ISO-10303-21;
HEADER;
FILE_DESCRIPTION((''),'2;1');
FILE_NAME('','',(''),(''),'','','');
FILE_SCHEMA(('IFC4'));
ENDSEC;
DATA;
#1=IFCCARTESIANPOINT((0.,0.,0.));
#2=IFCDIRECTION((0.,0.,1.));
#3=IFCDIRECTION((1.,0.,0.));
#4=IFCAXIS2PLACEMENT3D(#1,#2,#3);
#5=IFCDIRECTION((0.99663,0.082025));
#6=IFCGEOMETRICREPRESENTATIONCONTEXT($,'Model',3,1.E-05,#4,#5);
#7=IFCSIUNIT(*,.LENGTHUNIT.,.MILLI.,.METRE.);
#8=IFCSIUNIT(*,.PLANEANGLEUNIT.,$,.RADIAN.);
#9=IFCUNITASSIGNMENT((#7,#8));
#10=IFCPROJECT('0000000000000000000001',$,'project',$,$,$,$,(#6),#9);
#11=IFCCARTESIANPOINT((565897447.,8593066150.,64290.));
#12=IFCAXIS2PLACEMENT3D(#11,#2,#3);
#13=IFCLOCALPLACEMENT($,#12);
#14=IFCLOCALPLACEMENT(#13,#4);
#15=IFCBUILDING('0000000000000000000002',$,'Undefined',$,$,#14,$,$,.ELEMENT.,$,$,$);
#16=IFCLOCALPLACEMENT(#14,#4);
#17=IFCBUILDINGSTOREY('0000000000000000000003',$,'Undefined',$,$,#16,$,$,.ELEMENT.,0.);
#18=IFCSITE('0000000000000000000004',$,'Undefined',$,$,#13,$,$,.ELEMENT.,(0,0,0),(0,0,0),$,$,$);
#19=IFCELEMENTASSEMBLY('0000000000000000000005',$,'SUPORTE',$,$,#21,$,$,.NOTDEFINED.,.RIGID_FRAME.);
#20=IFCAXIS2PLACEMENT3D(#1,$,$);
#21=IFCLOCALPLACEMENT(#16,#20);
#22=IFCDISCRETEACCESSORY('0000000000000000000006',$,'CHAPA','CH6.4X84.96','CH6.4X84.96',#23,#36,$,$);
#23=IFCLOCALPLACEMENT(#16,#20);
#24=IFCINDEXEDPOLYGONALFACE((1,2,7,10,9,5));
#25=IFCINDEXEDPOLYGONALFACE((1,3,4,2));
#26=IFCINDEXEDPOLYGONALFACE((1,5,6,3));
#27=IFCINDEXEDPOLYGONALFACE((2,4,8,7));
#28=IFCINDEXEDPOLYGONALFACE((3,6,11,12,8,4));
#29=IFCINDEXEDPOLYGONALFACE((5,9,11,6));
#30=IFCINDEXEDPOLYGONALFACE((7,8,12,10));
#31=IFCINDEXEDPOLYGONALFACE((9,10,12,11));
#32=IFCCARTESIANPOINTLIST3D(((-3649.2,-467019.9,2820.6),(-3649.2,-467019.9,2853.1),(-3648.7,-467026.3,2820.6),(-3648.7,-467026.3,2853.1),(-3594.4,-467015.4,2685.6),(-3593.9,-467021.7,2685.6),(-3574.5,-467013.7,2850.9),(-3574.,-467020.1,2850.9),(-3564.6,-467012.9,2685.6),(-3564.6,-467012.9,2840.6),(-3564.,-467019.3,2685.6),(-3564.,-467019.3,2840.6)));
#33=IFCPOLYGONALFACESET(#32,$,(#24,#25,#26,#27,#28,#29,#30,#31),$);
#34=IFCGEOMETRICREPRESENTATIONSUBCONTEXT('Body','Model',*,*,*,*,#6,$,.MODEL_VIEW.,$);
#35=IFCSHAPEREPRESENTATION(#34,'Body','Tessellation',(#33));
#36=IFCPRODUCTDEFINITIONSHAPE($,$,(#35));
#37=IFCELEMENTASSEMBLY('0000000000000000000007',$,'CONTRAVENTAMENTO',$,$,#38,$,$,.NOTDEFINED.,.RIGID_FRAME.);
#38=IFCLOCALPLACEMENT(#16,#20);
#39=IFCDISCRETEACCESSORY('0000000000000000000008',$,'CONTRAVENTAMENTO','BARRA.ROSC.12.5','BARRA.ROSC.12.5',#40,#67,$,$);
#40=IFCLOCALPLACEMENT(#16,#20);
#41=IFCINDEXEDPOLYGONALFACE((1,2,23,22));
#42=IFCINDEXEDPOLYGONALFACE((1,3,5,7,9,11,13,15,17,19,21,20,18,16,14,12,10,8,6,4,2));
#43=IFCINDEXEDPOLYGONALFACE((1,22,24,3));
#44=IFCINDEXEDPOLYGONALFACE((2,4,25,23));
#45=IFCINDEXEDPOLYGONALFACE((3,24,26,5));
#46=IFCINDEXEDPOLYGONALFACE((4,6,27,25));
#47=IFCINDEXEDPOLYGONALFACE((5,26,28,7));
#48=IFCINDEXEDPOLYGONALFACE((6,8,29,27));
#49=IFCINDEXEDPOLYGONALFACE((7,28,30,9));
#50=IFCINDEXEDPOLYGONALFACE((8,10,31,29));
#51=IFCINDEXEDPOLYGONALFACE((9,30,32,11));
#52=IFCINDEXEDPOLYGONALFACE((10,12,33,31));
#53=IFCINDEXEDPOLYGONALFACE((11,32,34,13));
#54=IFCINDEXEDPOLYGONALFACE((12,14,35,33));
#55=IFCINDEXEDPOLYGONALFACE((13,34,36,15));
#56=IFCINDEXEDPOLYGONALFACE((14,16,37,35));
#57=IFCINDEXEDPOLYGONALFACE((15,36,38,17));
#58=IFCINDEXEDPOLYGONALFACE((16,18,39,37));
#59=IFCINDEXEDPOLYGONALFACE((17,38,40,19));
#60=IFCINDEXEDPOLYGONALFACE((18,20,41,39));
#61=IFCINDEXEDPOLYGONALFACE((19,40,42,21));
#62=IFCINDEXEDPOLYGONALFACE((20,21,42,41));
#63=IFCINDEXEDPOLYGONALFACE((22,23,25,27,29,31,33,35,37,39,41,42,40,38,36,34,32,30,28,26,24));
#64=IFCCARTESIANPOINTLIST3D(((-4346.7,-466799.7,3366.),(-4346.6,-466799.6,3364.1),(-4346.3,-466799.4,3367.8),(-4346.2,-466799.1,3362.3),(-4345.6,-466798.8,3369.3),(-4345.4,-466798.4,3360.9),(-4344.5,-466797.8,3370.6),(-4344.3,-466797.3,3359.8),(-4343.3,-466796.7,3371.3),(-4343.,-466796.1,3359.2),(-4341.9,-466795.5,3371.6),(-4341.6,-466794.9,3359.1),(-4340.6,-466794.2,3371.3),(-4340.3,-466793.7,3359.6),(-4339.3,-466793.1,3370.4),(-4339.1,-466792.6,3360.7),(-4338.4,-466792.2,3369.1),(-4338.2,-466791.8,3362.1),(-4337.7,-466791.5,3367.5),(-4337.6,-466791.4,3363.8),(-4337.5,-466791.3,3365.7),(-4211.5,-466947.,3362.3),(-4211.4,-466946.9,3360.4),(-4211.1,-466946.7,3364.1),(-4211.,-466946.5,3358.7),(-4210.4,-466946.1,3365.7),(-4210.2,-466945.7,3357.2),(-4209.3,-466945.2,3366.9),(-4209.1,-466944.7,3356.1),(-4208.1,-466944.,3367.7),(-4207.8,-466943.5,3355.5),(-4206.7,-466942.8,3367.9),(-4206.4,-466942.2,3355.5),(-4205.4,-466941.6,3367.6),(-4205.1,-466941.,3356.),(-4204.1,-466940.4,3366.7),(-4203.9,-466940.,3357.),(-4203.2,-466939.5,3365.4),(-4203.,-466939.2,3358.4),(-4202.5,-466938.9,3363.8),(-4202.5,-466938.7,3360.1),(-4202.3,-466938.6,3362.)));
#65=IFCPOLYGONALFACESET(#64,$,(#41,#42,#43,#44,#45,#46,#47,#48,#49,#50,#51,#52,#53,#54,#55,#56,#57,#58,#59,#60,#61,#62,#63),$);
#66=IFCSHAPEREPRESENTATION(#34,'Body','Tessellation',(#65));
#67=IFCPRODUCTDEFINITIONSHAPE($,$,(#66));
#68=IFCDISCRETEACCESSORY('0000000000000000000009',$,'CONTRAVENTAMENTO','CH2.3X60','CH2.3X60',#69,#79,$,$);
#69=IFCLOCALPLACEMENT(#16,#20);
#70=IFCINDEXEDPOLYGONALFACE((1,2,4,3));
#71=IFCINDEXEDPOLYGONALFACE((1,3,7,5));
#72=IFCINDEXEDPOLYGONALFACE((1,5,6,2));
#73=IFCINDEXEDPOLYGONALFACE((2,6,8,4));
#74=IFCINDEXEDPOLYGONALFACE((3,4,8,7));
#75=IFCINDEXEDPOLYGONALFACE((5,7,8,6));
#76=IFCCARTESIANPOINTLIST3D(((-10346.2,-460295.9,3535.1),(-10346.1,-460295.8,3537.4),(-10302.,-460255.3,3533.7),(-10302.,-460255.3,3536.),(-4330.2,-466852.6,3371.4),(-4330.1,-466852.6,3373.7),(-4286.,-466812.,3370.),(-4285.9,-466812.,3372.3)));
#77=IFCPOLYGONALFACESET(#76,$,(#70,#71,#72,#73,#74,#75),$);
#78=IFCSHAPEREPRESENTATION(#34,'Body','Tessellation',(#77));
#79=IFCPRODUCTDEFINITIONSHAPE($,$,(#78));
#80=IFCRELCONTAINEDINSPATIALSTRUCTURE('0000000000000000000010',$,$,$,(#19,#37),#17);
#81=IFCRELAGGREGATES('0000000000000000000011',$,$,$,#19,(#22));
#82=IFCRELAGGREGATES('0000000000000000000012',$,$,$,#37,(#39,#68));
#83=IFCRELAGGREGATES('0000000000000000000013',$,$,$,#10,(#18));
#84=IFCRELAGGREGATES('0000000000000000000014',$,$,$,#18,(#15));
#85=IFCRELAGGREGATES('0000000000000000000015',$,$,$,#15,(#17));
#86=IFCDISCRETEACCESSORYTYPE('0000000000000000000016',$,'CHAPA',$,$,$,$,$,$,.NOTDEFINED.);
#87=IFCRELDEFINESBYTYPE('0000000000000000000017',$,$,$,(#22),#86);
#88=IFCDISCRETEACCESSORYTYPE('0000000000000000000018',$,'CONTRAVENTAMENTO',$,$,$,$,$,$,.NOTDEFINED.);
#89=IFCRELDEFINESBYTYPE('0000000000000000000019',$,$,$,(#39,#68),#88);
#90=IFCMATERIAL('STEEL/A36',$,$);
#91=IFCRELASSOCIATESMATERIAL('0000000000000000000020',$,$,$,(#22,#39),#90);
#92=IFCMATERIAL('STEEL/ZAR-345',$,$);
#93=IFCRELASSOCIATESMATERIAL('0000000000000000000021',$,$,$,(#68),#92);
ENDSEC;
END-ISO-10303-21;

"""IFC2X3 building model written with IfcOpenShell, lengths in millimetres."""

from ifc_helpers import new_model, si_unit, direction, frame, origin_with_axes, origin_2d_with_axis, place, context, subcontext, project, spatial, polyline, circle, outline, extrude, material, type_object, element, aggregate, save


model = new_model("IFC2X3")

# Units and contexts
model_context = context("Model", 3, precision=1e-05, world=origin_with_axes(), true_north=direction((0.99663, 0.082025)))
body_context = subcontext(model_context, "Body", "Model", "MODEL_VIEW")
ifc_project = project(units=[si_unit("LENGTHUNIT", "METRE", prefix="MILLI"), si_unit("PLANEANGLEUNIT", "RADIAN")], contexts=[model_context])

# Site, building, storey
site_placement = place(None, frame((565897447.0, 8593066150.0, 64290.0), z_axis=(0.0, 0.0, 1.0), x_axis=(1.0, 0.0, 0.0)))
site = spatial("IfcSite", under=ifc_project, at=site_placement, Name="Undefined", CompositionType="ELEMENT", RefLatitude=(0, 0, 0), RefLongitude=(0, 0, 0))
building_placement = place(site_placement, origin_with_axes())
building = spatial("IfcBuilding", under=site, at=building_placement, Name="Undefined", CompositionType="ELEMENT")
storey_placement = place(building_placement, origin_with_axes())
storey = spatial("IfcBuildingStorey", under=building, at=storey_placement, Name="Undefined", CompositionType="ELEMENT", Elevation=0.0)

# Shared definitions
ifc_material_1 = material(Name="STEEL/A36")

# Shared definitions
discrete_accessory_type_1 = type_object("IfcDiscreteAccessoryType", Name="CHAPA")

# Element assembly, discrete accessory
assembly_1_placement = place(storey_placement, origin_with_axes())
assembly_1 = element("IfcElementAssembly", 1, at=assembly_1_placement, inside=storey, Name="SUPORTE", AssemblyPlace="NOTDEFINED", PredefinedType="RIGID_FRAME")
discrete_accessory_1_placement = place(assembly_1_placement, frame((-3564.3, -467016.1, 2850.6), z_axis=(-0.082025, 0.99663, 0.0), x_axis=(0.0, 0.0, -1.0)))
discrete_accessory_1 = element("IfcDiscreteAccessory", 2, at=discrete_accessory_1_placement, type_object=discrete_accessory_type_1, material=ifc_material_1, Name="CHAPA", Description="CH6.4X84.96", ObjectType="CH6.4X84.96", context=body_context, shape_type="SweptSolid", body=[
    extrude(outline(polyline([(-0.3, 10.0), (10.0, 0.0), (165.0, 0.0), (165.0, 30.0), (30.0, 85.0), (-2.5, 85.0), (-0.3, 10.0)])), frame((0.0, 0.0, -3.2), z_axis=(0.0, 0.0, 1.0), x_axis=(1.0, 0.0, 0.0)), (0.0, 0.0, 1.0), 6.4),
])
aggregate(assembly_1, [discrete_accessory_1])

# Element assembly, discrete accessories
assembly_2_placement = place(storey_placement, origin_with_axes())
assembly_2 = element("IfcElementAssembly", 3, at=assembly_2_placement, inside=storey, Name="CONTRAVENTAMENTO", AssemblyPlace="NOTDEFINED", PredefinedType="RIGID_FRAME")
discrete_accessory_type_2 = type_object("IfcDiscreteAccessoryType", Name="CONTRAVENTAMENTO")
discrete_accessory_2_placement = place(assembly_2_placement, frame((-4206.9, -466942.8, 3361.7), z_axis=(-0.736334, -0.676203, 0.02368), x_axis=(-0.675958, 0.736711, 0.018398)))
discrete_accessory_2 = element("IfcDiscreteAccessory", 4, at=discrete_accessory_2_placement, type_object=discrete_accessory_type_2, material=ifc_material_1, Name="CONTRAVENTAMENTO", Description="BARRA.ROSC.12.5", ObjectType="BARRA.ROSC.12.5", context=body_context, shape_type="SweptSolid", body=[
    extrude(circle(Radius=6.2, at=origin_2d_with_axis()), frame((200.0, 0.0, 0.0), z_axis=(-1.0, 0.0, 0.0), x_axis=(0.0, -1.0, 0.0)), (0.0, 0.0, 1.0), 200.0),
])
ifc_material_2 = material(Name="STEEL/ZAR-345")
discrete_accessory_3_placement = place(assembly_2_placement, frame((-4308.1, -466832.3, 3371.8), z_axis=(0.029885, 0.00246, 0.99955), x_axis=(-0.675958, 0.736711, 0.018398)))
discrete_accessory_3 = element("IfcDiscreteAccessory", 5, at=discrete_accessory_3_placement, type_object=discrete_accessory_type_2, material=ifc_material_2, Name="CONTRAVENTAMENTO", Description="CH2.3X60", ObjectType="CH2.3X60", context=body_context, shape_type="SweptSolid", body=[
    extrude(outline(polyline([(8900.0, -30.0), (0.0, -30.0), (0.0, 30.0), (8900.0, 30.0), (8900.0, -30.0)])), frame((0.0, 0.0, -1.1), z_axis=(0.0, 0.0, 1.0), x_axis=(1.0, 0.0, 0.0)), (0.0, 0.0, 1.0), 2.3),
])
aggregate(assembly_2, [discrete_accessory_2, discrete_accessory_3])

save(model, "model.ifc")
